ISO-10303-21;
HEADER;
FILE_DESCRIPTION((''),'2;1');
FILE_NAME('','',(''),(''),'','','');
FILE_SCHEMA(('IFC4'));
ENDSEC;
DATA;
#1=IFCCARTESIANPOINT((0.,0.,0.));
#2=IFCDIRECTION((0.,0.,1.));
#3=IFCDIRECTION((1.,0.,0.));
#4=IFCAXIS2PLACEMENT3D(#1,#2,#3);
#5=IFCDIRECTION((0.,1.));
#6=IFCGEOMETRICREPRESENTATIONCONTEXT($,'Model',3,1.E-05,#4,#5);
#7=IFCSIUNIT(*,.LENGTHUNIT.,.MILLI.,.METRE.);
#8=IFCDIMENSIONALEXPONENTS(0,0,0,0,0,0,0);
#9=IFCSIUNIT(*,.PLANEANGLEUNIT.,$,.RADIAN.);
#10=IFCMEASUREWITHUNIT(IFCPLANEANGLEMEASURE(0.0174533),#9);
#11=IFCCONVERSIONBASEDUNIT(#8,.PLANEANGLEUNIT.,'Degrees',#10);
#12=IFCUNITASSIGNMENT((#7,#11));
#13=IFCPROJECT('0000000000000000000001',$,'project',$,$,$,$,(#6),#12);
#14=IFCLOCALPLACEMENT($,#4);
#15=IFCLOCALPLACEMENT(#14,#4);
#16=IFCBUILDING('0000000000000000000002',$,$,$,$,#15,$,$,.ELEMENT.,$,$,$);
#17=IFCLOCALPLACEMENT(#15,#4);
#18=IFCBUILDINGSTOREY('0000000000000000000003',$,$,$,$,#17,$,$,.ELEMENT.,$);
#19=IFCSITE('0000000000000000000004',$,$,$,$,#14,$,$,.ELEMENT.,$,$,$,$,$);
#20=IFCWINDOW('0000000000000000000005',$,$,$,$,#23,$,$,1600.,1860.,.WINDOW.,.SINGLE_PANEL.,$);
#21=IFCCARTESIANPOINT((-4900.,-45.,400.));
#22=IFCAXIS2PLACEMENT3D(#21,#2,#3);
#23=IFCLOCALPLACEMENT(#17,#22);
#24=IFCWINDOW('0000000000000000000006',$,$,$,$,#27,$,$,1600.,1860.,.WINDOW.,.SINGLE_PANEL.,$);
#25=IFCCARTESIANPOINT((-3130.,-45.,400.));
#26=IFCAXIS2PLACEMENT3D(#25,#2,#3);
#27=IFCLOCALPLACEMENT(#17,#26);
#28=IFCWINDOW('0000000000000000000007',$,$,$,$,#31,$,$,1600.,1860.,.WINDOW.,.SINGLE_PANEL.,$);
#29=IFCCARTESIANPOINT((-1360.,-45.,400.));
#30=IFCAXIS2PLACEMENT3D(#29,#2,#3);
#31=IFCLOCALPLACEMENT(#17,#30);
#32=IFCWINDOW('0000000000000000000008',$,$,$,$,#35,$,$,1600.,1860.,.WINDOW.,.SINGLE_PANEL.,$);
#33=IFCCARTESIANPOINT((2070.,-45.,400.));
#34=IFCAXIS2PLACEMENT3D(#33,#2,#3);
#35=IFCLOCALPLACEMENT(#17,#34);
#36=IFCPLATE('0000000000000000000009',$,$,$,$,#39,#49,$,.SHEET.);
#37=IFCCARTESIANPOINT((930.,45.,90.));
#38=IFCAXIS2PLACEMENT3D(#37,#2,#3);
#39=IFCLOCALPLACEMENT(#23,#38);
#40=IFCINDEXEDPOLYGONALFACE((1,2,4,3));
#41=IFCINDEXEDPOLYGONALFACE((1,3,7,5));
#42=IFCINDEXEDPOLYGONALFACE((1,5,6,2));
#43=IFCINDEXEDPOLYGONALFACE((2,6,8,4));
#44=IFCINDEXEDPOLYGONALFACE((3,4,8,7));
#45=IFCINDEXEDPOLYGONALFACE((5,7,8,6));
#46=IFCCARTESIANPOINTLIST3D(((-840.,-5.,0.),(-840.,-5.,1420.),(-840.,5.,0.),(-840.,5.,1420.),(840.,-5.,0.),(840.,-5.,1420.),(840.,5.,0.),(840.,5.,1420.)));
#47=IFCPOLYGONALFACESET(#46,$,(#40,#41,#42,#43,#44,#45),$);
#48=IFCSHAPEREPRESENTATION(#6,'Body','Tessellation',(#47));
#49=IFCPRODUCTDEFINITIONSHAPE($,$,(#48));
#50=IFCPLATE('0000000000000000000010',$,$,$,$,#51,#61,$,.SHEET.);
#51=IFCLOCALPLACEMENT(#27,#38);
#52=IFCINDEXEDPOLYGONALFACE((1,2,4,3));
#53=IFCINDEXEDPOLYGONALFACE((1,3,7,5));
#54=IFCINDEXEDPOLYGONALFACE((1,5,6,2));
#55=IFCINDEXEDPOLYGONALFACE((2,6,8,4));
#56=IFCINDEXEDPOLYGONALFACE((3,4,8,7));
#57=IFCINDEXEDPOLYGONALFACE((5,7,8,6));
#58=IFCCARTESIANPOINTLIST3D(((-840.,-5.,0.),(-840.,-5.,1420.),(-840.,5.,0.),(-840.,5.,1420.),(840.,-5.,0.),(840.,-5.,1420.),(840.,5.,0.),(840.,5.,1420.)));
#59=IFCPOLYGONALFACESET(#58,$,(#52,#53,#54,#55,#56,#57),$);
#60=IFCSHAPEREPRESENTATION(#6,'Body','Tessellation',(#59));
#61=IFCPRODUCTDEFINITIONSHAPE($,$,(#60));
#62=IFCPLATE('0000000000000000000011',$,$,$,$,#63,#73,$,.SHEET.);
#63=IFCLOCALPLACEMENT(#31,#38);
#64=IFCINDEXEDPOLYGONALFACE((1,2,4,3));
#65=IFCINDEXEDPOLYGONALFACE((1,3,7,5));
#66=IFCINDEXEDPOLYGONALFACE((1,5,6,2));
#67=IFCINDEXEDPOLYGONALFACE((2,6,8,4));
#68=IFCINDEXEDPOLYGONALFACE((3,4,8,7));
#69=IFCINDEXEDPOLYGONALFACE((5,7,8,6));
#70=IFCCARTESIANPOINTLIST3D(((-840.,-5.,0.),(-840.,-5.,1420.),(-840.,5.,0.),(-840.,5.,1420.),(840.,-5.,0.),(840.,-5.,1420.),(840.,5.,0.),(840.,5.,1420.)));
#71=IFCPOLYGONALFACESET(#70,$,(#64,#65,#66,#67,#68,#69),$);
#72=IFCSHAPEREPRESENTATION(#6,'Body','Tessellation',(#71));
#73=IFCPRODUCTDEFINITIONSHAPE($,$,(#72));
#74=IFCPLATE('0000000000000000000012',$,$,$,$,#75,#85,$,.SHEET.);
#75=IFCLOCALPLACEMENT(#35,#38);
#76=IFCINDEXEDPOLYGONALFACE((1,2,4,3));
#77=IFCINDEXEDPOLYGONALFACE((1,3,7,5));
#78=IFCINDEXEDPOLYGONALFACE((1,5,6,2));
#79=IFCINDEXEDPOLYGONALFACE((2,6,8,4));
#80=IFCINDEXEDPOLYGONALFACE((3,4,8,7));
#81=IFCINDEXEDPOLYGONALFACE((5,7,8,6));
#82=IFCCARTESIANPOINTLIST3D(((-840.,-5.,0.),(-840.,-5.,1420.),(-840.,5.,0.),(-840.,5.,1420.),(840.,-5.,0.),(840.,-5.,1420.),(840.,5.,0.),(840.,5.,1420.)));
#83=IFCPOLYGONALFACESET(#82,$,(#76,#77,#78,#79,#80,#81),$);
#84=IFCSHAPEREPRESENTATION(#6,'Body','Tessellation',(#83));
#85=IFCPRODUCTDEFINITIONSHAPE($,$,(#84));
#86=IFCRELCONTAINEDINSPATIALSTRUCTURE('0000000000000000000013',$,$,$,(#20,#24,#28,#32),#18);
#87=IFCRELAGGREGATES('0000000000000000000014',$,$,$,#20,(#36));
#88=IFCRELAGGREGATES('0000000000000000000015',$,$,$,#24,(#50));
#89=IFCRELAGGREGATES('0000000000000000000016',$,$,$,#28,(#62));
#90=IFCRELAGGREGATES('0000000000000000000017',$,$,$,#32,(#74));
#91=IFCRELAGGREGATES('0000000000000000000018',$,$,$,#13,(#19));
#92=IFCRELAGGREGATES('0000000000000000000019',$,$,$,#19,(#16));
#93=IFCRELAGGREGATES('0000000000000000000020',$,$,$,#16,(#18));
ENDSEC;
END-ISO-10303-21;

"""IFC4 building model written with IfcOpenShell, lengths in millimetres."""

from ifc_helpers import new_model, entity, si_unit, converted_unit, direction, frame, origin_with_axes, place, context, project, spatial, polyline, outline, extrude, element, aggregate, save


model = new_model("IFC4")

# Units and contexts
model_context = context("Model", 3, precision=1e-05, world=origin_with_axes(), true_north=direction((0.0, 1.0)))
ifc_project = project(units=[si_unit("LENGTHUNIT", "METRE", prefix="MILLI"), converted_unit("PLANEANGLEUNIT", "Degrees", entity("IfcPlaneAngleMeasure", 0.0174533), si_unit("PLANEANGLEUNIT", "RADIAN"), dimensions=[0, 0, 0, 0, 0, 0, 0])], contexts=[model_context])

# Site, building, storey
site_placement = place(None, origin_with_axes())
site = spatial("IfcSite", under=ifc_project, at=site_placement, CompositionType="ELEMENT")
building_placement = place(site_placement, origin_with_axes())
building = spatial("IfcBuilding", under=site, at=building_placement, CompositionType="ELEMENT")
storey_placement = place(building_placement, origin_with_axes())
storey = spatial("IfcBuildingStorey", under=building, at=storey_placement, CompositionType="ELEMENT")

# Windows
window_1_placement = place(storey_placement, frame((-4900.0, -45.0, 400.0), z_axis=(0.0, 0.0, 1.0), x_axis=(1.0, 0.0, 0.0)))
window_1 = element("IfcWindow", 1, at=window_1_placement, inside=storey, OverallHeight=1600.0, OverallWidth=1860.0, PartitioningType="SINGLE_PANEL", PredefinedType="WINDOW")
window_2_placement = place(storey_placement, frame((-3130.0, -45.0, 400.0), z_axis=(0.0, 0.0, 1.0), x_axis=(1.0, 0.0, 0.0)))
window_2 = element("IfcWindow", 2, at=window_2_placement, inside=storey, OverallHeight=1600.0, OverallWidth=1860.0, PartitioningType="SINGLE_PANEL", PredefinedType="WINDOW")
window_3_placement = place(storey_placement, frame((-1360.0, -45.0, 400.0), z_axis=(0.0, 0.0, 1.0), x_axis=(1.0, 0.0, 0.0)))
window_3 = element("IfcWindow", 3, at=window_3_placement, inside=storey, OverallHeight=1600.0, OverallWidth=1860.0, PartitioningType="SINGLE_PANEL", PredefinedType="WINDOW")
window_4_placement = place(storey_placement, frame((2070.0, -45.0, 400.0), z_axis=(0.0, 0.0, 1.0), x_axis=(1.0, 0.0, 0.0)))
window_4 = element("IfcWindow", 4, at=window_4_placement, inside=storey, OverallHeight=1600.0, OverallWidth=1860.0, PartitioningType="SINGLE_PANEL", PredefinedType="WINDOW")

# Plates
plate_1_placement = place(window_1_placement, frame((930.0, 45.0, 90.0), z_axis=(0.0, 0.0, 1.0), x_axis=(1.0, 0.0, 0.0)))
plate_1 = element("IfcPlate", 5, at=plate_1_placement, PredefinedType="SHEET", context=model_context, shape_type="SweptSolid", body=[
    extrude(outline(polyline([(-840.0, -5.0), (840.0, -5.0), (840.0, 5.0), (-840.0, 5.0), (-840.0, -5.0), (-840.0, -5.0)])), origin_with_axes(), (0.0, 0.0, 1.0), 1420.0),
])
aggregate(window_1, [plate_1])
plate_2_placement = place(window_2_placement, frame((930.0, 45.0, 90.0), z_axis=(0.0, 0.0, 1.0), x_axis=(1.0, 0.0, 0.0)))
plate_2 = element("IfcPlate", 6, at=plate_2_placement, PredefinedType="SHEET", context=model_context, shape_type="SweptSolid", body=[
    extrude(outline(polyline([(-840.0, -5.0), (840.0, -5.0), (840.0, 5.0), (-840.0, 5.0), (-840.0, -5.0), (-840.0, -5.0)])), origin_with_axes(), (0.0, 0.0, 1.0), 1420.0),
])
aggregate(window_2, [plate_2])
plate_3_placement = place(window_3_placement, frame((930.0, 45.0, 90.0), z_axis=(0.0, 0.0, 1.0), x_axis=(1.0, 0.0, 0.0)))
plate_3 = element("IfcPlate", 7, at=plate_3_placement, PredefinedType="SHEET", context=model_context, shape_type="SweptSolid", body=[
    extrude(outline(polyline([(-840.0, -5.0), (840.0, -5.0), (840.0, 5.0), (-840.0, 5.0), (-840.0, -5.0), (-840.0, -5.0)])), origin_with_axes(), (0.0, 0.0, 1.0), 1420.0),
])
aggregate(window_3, [plate_3])
plate_4_placement = place(window_4_placement, frame((930.0, 45.0, 90.0), z_axis=(0.0, 0.0, 1.0), x_axis=(1.0, 0.0, 0.0)))
plate_4 = element("IfcPlate", 8, at=plate_4_placement, PredefinedType="SHEET", context=model_context, shape_type="SweptSolid", body=[
    extrude(outline(polyline([(-840.0, -5.0), (840.0, -5.0), (840.0, 5.0), (-840.0, 5.0), (-840.0, -5.0), (-840.0, -5.0)])), origin_with_axes(), (0.0, 0.0, 1.0), 1420.0),
])
aggregate(window_4, [plate_4])

save(model, "model.ifc")
